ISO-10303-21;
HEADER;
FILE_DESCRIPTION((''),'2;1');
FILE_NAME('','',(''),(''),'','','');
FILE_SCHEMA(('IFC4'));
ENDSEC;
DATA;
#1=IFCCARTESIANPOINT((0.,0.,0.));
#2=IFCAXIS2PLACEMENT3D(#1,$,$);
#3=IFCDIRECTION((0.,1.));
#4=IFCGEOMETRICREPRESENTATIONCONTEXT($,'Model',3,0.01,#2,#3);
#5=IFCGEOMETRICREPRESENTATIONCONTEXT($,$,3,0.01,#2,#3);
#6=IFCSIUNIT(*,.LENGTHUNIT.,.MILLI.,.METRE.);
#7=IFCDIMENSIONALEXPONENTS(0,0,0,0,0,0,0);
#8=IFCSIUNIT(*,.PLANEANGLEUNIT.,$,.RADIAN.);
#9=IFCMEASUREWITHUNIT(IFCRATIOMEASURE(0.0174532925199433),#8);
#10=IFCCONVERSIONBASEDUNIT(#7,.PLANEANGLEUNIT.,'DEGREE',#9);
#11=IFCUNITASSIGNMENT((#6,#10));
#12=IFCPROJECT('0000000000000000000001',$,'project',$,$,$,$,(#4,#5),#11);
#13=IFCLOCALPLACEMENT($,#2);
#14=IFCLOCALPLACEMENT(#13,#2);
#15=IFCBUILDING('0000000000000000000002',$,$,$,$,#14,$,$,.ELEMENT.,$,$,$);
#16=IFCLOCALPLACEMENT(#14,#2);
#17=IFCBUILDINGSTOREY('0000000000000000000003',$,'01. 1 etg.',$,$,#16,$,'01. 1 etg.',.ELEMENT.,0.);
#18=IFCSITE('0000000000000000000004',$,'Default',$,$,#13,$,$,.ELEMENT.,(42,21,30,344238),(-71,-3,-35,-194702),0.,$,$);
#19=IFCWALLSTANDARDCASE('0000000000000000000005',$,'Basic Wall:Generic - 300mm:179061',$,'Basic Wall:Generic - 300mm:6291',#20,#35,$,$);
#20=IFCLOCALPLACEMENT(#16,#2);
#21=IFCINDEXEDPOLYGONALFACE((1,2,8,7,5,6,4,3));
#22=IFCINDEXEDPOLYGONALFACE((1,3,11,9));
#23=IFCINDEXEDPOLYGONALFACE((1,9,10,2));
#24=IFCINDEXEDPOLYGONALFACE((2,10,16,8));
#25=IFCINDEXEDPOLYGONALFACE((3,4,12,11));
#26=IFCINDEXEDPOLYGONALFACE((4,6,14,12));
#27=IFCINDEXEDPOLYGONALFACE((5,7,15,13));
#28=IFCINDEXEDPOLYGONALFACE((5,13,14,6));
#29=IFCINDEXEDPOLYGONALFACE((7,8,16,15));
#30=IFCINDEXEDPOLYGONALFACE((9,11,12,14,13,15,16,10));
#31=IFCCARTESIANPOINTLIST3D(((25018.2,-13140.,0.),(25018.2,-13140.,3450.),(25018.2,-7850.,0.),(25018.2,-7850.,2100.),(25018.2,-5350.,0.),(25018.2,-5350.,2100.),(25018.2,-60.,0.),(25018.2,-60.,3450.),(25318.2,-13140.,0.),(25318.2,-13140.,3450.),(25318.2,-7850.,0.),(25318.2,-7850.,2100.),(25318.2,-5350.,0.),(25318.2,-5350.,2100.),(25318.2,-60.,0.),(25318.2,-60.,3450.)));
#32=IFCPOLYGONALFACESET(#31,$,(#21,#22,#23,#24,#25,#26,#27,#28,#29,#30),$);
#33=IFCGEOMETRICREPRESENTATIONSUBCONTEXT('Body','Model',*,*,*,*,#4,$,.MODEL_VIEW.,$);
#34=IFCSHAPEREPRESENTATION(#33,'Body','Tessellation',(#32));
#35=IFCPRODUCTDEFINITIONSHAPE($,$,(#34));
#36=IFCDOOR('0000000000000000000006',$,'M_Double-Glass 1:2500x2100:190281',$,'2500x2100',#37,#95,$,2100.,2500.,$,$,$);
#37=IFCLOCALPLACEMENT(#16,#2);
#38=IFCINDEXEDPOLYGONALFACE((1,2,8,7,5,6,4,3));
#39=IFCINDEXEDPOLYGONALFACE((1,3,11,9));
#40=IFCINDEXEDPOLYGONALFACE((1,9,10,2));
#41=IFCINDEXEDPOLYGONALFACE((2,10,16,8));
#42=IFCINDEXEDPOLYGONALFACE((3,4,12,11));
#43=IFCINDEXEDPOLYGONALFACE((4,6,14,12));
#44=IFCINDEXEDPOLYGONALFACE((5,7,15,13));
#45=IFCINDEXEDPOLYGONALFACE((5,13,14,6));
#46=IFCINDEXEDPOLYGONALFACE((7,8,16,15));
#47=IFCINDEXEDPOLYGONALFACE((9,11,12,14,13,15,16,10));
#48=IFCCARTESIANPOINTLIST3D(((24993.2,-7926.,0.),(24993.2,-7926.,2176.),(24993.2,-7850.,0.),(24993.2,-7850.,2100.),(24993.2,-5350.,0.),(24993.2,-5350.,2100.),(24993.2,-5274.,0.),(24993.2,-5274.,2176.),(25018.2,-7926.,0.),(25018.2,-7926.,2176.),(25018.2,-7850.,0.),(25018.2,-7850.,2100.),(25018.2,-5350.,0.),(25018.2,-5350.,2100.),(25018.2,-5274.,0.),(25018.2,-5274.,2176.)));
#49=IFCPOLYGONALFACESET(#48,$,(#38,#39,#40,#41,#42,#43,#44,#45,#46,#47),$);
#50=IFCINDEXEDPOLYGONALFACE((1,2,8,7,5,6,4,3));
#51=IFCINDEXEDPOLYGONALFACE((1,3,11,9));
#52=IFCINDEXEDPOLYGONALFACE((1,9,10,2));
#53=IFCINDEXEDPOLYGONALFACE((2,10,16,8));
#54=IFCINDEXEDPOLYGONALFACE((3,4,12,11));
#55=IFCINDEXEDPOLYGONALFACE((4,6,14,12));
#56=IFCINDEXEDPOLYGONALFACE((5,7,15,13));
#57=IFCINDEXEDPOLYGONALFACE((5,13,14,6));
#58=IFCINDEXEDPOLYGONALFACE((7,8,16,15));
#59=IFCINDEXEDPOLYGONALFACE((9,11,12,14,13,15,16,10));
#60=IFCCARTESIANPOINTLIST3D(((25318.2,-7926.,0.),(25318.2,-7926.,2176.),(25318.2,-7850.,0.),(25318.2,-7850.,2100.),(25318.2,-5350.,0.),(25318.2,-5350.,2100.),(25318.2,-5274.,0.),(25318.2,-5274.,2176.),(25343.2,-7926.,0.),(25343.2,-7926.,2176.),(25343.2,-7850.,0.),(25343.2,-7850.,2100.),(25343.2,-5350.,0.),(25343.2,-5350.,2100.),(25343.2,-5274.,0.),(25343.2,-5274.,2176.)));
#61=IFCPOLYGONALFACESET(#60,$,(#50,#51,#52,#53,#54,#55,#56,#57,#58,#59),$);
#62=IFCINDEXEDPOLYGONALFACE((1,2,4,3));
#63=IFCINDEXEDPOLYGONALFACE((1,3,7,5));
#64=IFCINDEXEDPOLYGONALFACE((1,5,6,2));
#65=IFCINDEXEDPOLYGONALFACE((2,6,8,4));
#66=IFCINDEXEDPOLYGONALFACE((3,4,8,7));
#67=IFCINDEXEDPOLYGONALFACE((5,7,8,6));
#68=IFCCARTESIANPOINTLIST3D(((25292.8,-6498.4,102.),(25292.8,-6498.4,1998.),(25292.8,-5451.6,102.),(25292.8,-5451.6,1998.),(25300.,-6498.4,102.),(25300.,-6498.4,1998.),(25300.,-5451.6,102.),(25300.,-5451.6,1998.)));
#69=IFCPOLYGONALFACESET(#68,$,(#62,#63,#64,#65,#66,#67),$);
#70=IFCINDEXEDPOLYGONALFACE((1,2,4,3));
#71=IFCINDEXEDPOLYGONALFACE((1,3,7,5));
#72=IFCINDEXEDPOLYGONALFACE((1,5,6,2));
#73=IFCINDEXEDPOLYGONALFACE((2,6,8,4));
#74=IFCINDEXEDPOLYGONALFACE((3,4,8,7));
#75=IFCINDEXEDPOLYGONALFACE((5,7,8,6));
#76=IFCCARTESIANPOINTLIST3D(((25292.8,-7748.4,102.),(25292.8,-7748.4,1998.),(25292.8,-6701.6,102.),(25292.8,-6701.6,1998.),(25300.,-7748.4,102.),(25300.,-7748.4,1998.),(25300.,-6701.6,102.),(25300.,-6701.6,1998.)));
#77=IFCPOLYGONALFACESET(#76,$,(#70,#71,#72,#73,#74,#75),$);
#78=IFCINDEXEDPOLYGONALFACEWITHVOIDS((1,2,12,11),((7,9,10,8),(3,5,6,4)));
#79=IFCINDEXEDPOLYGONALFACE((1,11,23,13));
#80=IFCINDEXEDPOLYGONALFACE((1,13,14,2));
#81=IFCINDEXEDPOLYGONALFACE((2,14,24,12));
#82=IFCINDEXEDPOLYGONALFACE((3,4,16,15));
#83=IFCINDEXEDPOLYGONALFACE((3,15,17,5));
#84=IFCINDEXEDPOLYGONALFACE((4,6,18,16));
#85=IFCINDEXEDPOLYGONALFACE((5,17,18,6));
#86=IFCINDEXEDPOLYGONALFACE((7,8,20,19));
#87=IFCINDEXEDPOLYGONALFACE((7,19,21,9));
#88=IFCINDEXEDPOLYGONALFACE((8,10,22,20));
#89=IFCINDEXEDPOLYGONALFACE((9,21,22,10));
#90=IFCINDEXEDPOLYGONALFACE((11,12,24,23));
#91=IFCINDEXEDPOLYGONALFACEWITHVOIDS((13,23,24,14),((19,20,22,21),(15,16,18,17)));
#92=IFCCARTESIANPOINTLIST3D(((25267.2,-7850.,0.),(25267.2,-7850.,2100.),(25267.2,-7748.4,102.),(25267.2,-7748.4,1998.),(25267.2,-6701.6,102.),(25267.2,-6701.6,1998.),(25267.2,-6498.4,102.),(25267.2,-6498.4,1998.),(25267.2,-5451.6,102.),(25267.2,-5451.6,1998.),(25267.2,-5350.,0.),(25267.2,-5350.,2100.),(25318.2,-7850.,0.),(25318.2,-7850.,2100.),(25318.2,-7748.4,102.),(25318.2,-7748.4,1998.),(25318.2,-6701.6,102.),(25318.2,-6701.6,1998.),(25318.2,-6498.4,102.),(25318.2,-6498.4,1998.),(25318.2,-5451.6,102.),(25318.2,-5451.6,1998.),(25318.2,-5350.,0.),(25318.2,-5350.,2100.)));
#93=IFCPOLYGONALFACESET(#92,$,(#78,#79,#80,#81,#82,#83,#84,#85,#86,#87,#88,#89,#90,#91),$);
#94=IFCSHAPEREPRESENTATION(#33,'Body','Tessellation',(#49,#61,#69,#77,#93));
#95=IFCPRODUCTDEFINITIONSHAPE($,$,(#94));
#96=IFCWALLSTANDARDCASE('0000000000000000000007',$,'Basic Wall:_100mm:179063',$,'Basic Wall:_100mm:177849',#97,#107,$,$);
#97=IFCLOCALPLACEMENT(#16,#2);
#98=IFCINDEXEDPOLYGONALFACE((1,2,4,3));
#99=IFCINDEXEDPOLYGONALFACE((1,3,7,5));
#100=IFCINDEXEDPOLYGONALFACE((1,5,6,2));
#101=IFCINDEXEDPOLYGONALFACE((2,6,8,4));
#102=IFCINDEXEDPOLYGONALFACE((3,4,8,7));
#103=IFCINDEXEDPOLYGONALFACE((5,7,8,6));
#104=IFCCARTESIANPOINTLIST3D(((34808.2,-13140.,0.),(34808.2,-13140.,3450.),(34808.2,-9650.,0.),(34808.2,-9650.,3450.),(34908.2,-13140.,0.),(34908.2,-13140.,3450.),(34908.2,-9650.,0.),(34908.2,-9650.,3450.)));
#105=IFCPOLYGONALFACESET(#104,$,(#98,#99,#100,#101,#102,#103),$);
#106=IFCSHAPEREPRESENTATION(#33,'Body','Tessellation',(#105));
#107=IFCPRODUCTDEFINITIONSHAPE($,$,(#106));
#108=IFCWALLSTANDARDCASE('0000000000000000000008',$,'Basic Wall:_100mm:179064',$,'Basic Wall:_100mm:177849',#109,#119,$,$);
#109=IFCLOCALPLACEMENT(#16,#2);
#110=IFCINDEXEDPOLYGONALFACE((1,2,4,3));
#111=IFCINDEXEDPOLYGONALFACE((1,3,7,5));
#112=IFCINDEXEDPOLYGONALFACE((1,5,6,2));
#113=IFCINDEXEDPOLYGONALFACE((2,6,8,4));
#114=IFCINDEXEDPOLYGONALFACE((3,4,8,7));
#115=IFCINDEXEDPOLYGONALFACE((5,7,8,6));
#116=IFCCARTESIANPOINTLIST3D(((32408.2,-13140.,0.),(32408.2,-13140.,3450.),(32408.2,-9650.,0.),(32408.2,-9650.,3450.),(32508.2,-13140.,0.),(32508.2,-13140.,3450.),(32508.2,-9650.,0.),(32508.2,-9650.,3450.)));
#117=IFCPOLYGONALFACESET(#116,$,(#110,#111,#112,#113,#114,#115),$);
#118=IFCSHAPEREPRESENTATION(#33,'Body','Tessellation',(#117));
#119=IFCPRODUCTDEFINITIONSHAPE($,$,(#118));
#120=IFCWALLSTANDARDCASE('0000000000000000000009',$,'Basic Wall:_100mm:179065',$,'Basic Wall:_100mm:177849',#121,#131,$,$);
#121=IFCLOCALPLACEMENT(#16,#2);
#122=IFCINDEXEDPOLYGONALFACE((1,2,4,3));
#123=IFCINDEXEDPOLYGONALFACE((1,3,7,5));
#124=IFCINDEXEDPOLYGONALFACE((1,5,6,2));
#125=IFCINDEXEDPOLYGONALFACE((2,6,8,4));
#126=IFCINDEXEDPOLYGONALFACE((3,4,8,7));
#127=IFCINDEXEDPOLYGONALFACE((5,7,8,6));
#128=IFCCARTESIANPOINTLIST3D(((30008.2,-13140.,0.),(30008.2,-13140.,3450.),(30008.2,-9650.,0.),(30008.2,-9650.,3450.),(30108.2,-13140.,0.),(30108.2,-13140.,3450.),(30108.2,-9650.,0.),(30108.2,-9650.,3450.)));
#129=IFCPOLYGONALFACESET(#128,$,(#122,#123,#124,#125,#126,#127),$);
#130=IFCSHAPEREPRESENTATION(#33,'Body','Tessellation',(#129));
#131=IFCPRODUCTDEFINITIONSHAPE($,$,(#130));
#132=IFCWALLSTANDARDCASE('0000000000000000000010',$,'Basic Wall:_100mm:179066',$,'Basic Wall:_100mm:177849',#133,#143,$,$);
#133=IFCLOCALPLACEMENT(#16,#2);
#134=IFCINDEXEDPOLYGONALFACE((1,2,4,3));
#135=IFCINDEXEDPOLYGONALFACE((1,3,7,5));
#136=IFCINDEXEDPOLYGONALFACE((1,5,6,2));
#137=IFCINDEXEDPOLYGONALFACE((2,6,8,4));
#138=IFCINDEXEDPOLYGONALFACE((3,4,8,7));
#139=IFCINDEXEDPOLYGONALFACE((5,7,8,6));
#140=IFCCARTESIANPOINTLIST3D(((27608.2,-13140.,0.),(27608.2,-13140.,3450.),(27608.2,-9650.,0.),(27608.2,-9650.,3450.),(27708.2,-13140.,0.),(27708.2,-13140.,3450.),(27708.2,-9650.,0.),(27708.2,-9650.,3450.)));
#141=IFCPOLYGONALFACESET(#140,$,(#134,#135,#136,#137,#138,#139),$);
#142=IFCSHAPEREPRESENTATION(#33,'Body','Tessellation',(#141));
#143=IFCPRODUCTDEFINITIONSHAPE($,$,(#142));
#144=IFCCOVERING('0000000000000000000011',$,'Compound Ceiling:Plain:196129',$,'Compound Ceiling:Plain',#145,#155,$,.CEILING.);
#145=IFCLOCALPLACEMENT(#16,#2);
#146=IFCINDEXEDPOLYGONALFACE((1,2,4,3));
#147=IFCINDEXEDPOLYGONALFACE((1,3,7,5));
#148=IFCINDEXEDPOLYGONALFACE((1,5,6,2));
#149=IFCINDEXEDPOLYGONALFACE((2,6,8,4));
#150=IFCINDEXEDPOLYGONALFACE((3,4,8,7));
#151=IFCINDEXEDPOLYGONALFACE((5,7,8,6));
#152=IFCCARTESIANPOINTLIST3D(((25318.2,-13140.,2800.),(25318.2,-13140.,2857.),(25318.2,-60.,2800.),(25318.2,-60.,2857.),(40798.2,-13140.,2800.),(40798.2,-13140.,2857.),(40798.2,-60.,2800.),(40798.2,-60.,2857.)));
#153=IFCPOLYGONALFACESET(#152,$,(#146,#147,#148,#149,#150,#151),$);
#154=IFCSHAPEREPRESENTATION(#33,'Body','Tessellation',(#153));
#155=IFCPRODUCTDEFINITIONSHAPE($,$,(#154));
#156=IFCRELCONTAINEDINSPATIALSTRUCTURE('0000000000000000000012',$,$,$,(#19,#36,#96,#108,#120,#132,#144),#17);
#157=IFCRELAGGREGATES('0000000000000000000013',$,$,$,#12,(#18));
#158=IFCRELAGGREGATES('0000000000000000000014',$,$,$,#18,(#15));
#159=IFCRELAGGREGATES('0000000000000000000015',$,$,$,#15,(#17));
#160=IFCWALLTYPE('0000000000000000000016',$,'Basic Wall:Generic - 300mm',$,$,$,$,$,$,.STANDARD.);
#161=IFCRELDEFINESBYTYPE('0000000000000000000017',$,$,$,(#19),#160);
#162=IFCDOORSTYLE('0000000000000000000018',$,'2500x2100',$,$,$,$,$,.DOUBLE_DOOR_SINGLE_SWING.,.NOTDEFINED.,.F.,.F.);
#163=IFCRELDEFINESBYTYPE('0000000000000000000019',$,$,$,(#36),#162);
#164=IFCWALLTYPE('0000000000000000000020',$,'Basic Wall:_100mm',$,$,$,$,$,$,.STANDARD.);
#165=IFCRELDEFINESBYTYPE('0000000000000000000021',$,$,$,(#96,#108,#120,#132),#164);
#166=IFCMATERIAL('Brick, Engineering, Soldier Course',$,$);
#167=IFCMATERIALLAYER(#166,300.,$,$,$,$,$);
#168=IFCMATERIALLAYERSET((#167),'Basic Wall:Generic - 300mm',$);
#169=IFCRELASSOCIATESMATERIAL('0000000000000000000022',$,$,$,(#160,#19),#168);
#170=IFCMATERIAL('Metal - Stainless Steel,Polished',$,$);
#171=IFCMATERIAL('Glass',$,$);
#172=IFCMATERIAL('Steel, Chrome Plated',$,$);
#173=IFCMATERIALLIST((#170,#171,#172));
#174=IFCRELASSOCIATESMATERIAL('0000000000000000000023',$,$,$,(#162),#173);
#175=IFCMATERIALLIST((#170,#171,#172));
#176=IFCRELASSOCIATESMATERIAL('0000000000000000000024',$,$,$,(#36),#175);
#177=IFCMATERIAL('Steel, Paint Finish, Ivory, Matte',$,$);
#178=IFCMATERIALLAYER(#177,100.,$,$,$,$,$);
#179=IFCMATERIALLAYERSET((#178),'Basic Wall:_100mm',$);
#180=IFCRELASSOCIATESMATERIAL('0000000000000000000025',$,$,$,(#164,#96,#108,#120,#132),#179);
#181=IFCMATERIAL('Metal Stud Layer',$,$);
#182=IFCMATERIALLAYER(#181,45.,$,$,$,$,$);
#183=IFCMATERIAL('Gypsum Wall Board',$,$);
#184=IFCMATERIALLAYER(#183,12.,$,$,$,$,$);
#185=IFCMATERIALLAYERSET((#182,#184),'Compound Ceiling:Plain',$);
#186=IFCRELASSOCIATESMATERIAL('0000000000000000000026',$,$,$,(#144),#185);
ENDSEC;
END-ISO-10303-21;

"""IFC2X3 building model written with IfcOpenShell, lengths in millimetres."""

from ifc_helpers import new_model, entity, si_unit, converted_unit, direction, frame, frame_2d, origin, place, context, subcontext, project, spatial, polyline, rectangle, outline, extrude, clip, bounded_halfspace, source, transform, mapped, material, material_list, layer, layer_set, layer_usage, type_object, type_shapes, element, fill, save


model = new_model("IFC2X3")

# Units and contexts
model_context = context("Model", 3, precision=0.01, world=origin(), true_north=direction((0.0, 1.0)))
context_of_model = context(None, 3, precision=0.01, world=origin(), true_north=direction((0.0, 1.0)))
body_context = subcontext(model_context, "Body", "Model", "MODEL_VIEW")
ifc_project = project(units=[si_unit("LENGTHUNIT", "METRE", prefix="MILLI"), converted_unit("PLANEANGLEUNIT", "DEGREE", entity("IfcRatioMeasure", 0.0174532925199433), si_unit("PLANEANGLEUNIT", "RADIAN"), dimensions=[0, 0, 0, 0, 0, 0, 0])], contexts=[model_context, context_of_model])

# Site, building, storey
site_placement = place(None, origin())
site = spatial("IfcSite", under=ifc_project, at=site_placement, Name="Default", CompositionType="ELEMENT", RefLatitude=(42, 21, 30, 344238), RefLongitude=(-71, -3, -35, -194702), RefElevation=0.0)
building_placement = place(site_placement, origin())
building = spatial("IfcBuilding", under=site, at=building_placement, CompositionType="ELEMENT")
storey_placement = place(building_placement, origin())
storey = spatial("IfcBuildingStorey", under=building, at=storey_placement, Name="01. 1 etg.", LongName="01. 1 etg.", CompositionType="ELEMENT", Elevation=0.0)

# Shared definitions
ifc_material_1 = material(Name="Glass")

# Shared definitions
ifc_material_2 = material(Name="Brick, Engineering, Soldier Course")
ifc_layer_1 = layer(ifc_material_2, 300.0)
ifc_layer_set_1 = layer_set([ifc_layer_1], Name="Basic Wall:Generic - 300mm")
wall_type_1 = type_object("IfcWallType", Name="Basic Wall:Generic - 300mm", PredefinedType="STANDARD", material=ifc_layer_set_1)

# Wall, opening, door
ifc_layer_usage_1 = layer_usage(ifc_layer_set_1, "AXIS2", "NEGATIVE", 150.0)
wall_1_placement = place(storey_placement, frame((25168.2, -13140.0, 0.0), z_axis=(0.0, 0.0, 1.0), x_axis=(0.0, 1.0, 0.0)))
wall_1 = element("IfcWallStandardCase", 1, at=wall_1_placement, inside=storey, type_object=wall_type_1, material=ifc_layer_usage_1, Name="Basic Wall:Generic - 300mm:179061", ObjectType="Basic Wall:Generic - 300mm:6291", context=body_context, shape_type="Clipping", body=[
    clip(extrude(rectangle(XDim=13080.0, YDim=300.0, at=frame_2d((6540.0, 0.0), x_axis=(-1.0, 0.0))), origin(), (0.0, 0.0, 1.0), 3450.0), bounded_halfspace(frame((3590.0, -150.0, 3450.0), z_axis=(0.0, 0.0, -1.0), x_axis=(-1.0, 0.0, 0.0)), True, frame((3590.0, -150.0, 3450.0)), polyline([(0.0, 0.0), (10.0, 0.0), (5900.0, 0.0), (5900.0, 300.0), (10.0, 300.0), (0.0, 300.0), (0.0, 0.0)]))),
])
opening_1_placement = place(wall_1_placement, frame((7790.0, 150.0, 0.0)))
opening_1 = element("IfcOpeningElement", 2, at=opening_1_placement, cuts=wall_1, ObjectType="Opening", context=body_context, shape_type="SweptSolid", body=[
    extrude(rectangle(XDim=2500.0, YDim=2100.0, at=frame_2d((1050.0, 1250.0), x_axis=(0.0, -1.0))), frame((0.0, 0.0, 0.0), z_axis=(0.0, -1.0, 0.0), x_axis=(0.0, 0.0, 1.0)), (0.0, 0.0, 1.0), 300.0),
])
ifc_material_3 = material(Name="Metal - Stainless Steel,Polished")
ifc_material_4 = material(Name="Steel, Chrome Plated")
ifc_material_list_1 = material_list([ifc_material_3, ifc_material_1, ifc_material_4])
ifc_material_list_2 = material_list([ifc_material_3, ifc_material_1, ifc_material_4])
door_style_1 = type_object("IfcDoorStyle", Name="2500x2100", ConstructionType="NOTDEFINED", OperationType="DOUBLE_DOOR_SINGLE_SWING", ParameterTakesPrecedence=False, Sizeable=False, material=ifc_material_list_2)
shared_shape_1 = source(origin(), body_context, "Body", "SweptSolid", [
    extrude(outline(polyline([(-1326.0, -1069.0), (-1250.0, -1069.0), (-1250.0, 1031.0), (1250.0, 1031.0), (1250.0, -1069.0), (1326.0, -1069.0), (1326.0, 1107.0), (-1326.0, 1107.0), (-1326.0, -1069.0)])), frame((1250.0, 4.8, 1069.0), z_axis=(0.0, -1.0, 0.0), x_axis=(1.0, 0.0, 0.0)), (0.0, 0.0, 1.0), 25.0),
    extrude(outline(polyline([(-1250.0, -1031.0), (-1250.0, 1069.0), (-1326.0, 1069.0), (-1326.0, -1107.0), (1326.0, -1107.0), (1326.0, 1069.0), (1250.0, 1069.0), (1250.0, -1031.0), (-1250.0, -1031.0)])), frame((1250.0, 329.8, 1069.0), z_axis=(0.0, 1.0, 0.0), x_axis=(1.0, 0.0, 0.0)), (0.0, 0.0, -1.0), 25.0),
    extrude(rectangle(XDim=1046.8, YDim=7.1, at=frame_2d((0.0, 0.0), x_axis=(1.0, 0.0))), frame((625.0, 282.9, 102.0)), (0.0, 0.0, 1.0), 1896.0),
    extrude(rectangle(XDim=1046.8, YDim=7.1, at=frame_2d((0.0, 0.0), x_axis=(1.0, 0.0))), frame((1875.0, 282.9, 102.0)), (0.0, 0.0, 1.0), 1896.0),
    extrude(outline(polyline([(-1050.0, -1250.0), (1050.0, -1250.0), (1050.0, 1250.0), (-1050.0, 1250.0), (-1050.0, -1250.0)]), holes=[polyline([(-948.0, 101.6), (-948.0, 1148.4), (948.0, 1148.4), (948.0, 101.6), (-948.0, 101.6)]), polyline([(-948.0, -1148.4), (-948.0, -101.6), (948.0, -101.6), (948.0, -1148.4), (-948.0, -1148.4)])]), frame((1250.0, 304.8, 1050.0), z_axis=(0.0, -1.0, 0.0), x_axis=(0.0, 0.0, -1.0)), (0.0, 0.0, 1.0), 51.0),
])
type_shapes(door_style_1, [shared_shape_1])
door_1_placement = place(opening_1_placement, frame((0.0, 4.8, 0.0), z_axis=(0.0, 0.0, 1.0), x_axis=(-1.0, 0.0, 0.0)))
door_1 = element("IfcDoor", 3, at=door_1_placement, inside=storey, type_object=door_style_1, material=ifc_material_list_1, Name="M_Double-Glass 1:2500x2100:190281", ObjectType="2500x2100", OverallHeight=2100.0, OverallWidth=2500.0, context=body_context, shape_type="MappedRepresentation", body=[
    mapped(shared_shape_1, transform((0.0, 0.0, 0.0), scale=1.0)),
])
fill(opening_1, door_1)

# Shared definitions
ifc_material_5 = material(Name="Steel, Paint Finish, Ivory, Matte")
ifc_layer_2 = layer(ifc_material_5, 100.0)
ifc_layer_set_2 = layer_set([ifc_layer_2], Name="Basic Wall:_100mm")
wall_type_2 = type_object("IfcWallType", Name="Basic Wall:_100mm", PredefinedType="STANDARD", material=ifc_layer_set_2)

# Walls
ifc_layer_usage_2 = layer_usage(ifc_layer_set_2, "AXIS2", "POSITIVE", -50.0)
wall_2_placement = place(storey_placement, frame((34858.2, -13140.0, 0.0), z_axis=(0.0, 0.0, 1.0), x_axis=(0.0, 1.0, 0.0)))
element("IfcWallStandardCase", 4, at=wall_2_placement, inside=storey, type_object=wall_type_2, material=ifc_layer_usage_2, Name="Basic Wall:_100mm:179063", ObjectType="Basic Wall:_100mm:177849", context=body_context, shape_type="Clipping", body=[
    clip(extrude(rectangle(XDim=3490.0, YDim=100.0, at=frame_2d((1745.0, 0.0), x_axis=(-1.0, 0.0))), origin(), (0.0, 0.0, 1.0), 3450.0), bounded_halfspace(frame((0.0, -50.0, 3450.0), z_axis=(0.0, 0.0, -1.0), x_axis=(-1.0, 0.0, 0.0)), True, frame((0.0, -50.0, 3450.0)), polyline([(0.0, 0.0), (3490.0, 0.0), (3490.0, 100.0), (0.0, 100.0), (0.0, 0.0)]))),
])
ifc_layer_usage_3 = layer_usage(ifc_layer_set_2, "AXIS2", "POSITIVE", -50.0)
wall_3_placement = place(storey_placement, frame((32458.2, -13140.0, 0.0), z_axis=(0.0, 0.0, 1.0), x_axis=(0.0, 1.0, 0.0)))
element("IfcWallStandardCase", 5, at=wall_3_placement, inside=storey, type_object=wall_type_2, material=ifc_layer_usage_3, Name="Basic Wall:_100mm:179064", ObjectType="Basic Wall:_100mm:177849", context=body_context, shape_type="Clipping", body=[
    clip(extrude(rectangle(XDim=3490.0, YDim=100.0, at=frame_2d((1745.0, 0.0), x_axis=(-1.0, 0.0))), origin(), (0.0, 0.0, 1.0), 3450.0), bounded_halfspace(frame((0.0, -50.0, 3450.0), z_axis=(0.0, 0.0, -1.0), x_axis=(-1.0, 0.0, 0.0)), True, frame((0.0, -50.0, 3450.0)), polyline([(0.0, 0.0), (3490.0, 0.0), (3490.0, 100.0), (0.0, 100.0), (0.0, 0.0)]))),
])
ifc_layer_usage_4 = layer_usage(ifc_layer_set_2, "AXIS2", "POSITIVE", -50.0)
wall_4_placement = place(storey_placement, frame((30058.2, -13140.0, 0.0), z_axis=(0.0, 0.0, 1.0), x_axis=(0.0, 1.0, 0.0)))
element("IfcWallStandardCase", 6, at=wall_4_placement, inside=storey, type_object=wall_type_2, material=ifc_layer_usage_4, Name="Basic Wall:_100mm:179065", ObjectType="Basic Wall:_100mm:177849", context=body_context, shape_type="Clipping", body=[
    clip(extrude(rectangle(XDim=3490.0, YDim=100.0, at=frame_2d((1745.0, 0.0), x_axis=(-1.0, 0.0))), origin(), (0.0, 0.0, 1.0), 3450.0), bounded_halfspace(frame((0.0, -50.0, 3450.0), z_axis=(0.0, 0.0, -1.0), x_axis=(-1.0, 0.0, 0.0)), True, frame((0.0, -50.0, 3450.0)), polyline([(0.0, 0.0), (3490.0, 0.0), (3490.0, 100.0), (0.0, 100.0), (0.0, 0.0)]))),
])
ifc_layer_usage_5 = layer_usage(ifc_layer_set_2, "AXIS2", "POSITIVE", -50.0)
wall_5_placement = place(storey_placement, frame((27658.2, -13140.0, 0.0), z_axis=(0.0, 0.0, 1.0), x_axis=(0.0, 1.0, 0.0)))
element("IfcWallStandardCase", 7, at=wall_5_placement, inside=storey, type_object=wall_type_2, material=ifc_layer_usage_5, Name="Basic Wall:_100mm:179066", ObjectType="Basic Wall:_100mm:177849", context=body_context, shape_type="Clipping", body=[
    clip(extrude(rectangle(XDim=3490.0, YDim=100.0, at=frame_2d((1745.0, 0.0), x_axis=(-1.0, 0.0))), origin(), (0.0, 0.0, 1.0), 3450.0), bounded_halfspace(frame((0.0, -50.0, 3450.0), z_axis=(0.0, 0.0, -1.0), x_axis=(-1.0, 0.0, 0.0)), True, frame((0.0, -50.0, 3450.0)), polyline([(0.0, 0.0), (3490.0, 0.0), (3490.0, 100.0), (0.0, 100.0), (0.0, 0.0)]))),
])

# Covering
ifc_material_6 = material(Name="Metal Stud Layer")
ifc_layer_3 = layer(ifc_material_6, 45.0)
ifc_material_7 = material(Name="Gypsum Wall Board")
ifc_layer_4 = layer(ifc_material_7, 12.0)
ifc_layer_set_3 = layer_set([ifc_layer_3, ifc_layer_4], Name="Compound Ceiling:Plain")
ifc_layer_usage_6 = layer_usage(ifc_layer_set_3, "AXIS3", "NEGATIVE", 0.0)
covering_placement = place(storey_placement, frame((25318.2, -13140.0, 2800.0)))
element("IfcCovering", 8, at=covering_placement, inside=storey, material=ifc_layer_usage_6, Name="Compound Ceiling:Plain:196129", ObjectType="Compound Ceiling:Plain", PredefinedType="CEILING", context=body_context, shape_type="SweptSolid", body=[
    extrude(rectangle(XDim=13080.0, YDim=15480.0, at=frame_2d((0.0, 0.0), x_axis=(1.0, 0.0))), frame((7740.0, 6540.0, 0.0), z_axis=(0.0, 0.0, 1.0), x_axis=(0.0, -1.0, 0.0)), (0.0, 0.0, 1.0), 57.0),
])

save(model, "model.ifc")
